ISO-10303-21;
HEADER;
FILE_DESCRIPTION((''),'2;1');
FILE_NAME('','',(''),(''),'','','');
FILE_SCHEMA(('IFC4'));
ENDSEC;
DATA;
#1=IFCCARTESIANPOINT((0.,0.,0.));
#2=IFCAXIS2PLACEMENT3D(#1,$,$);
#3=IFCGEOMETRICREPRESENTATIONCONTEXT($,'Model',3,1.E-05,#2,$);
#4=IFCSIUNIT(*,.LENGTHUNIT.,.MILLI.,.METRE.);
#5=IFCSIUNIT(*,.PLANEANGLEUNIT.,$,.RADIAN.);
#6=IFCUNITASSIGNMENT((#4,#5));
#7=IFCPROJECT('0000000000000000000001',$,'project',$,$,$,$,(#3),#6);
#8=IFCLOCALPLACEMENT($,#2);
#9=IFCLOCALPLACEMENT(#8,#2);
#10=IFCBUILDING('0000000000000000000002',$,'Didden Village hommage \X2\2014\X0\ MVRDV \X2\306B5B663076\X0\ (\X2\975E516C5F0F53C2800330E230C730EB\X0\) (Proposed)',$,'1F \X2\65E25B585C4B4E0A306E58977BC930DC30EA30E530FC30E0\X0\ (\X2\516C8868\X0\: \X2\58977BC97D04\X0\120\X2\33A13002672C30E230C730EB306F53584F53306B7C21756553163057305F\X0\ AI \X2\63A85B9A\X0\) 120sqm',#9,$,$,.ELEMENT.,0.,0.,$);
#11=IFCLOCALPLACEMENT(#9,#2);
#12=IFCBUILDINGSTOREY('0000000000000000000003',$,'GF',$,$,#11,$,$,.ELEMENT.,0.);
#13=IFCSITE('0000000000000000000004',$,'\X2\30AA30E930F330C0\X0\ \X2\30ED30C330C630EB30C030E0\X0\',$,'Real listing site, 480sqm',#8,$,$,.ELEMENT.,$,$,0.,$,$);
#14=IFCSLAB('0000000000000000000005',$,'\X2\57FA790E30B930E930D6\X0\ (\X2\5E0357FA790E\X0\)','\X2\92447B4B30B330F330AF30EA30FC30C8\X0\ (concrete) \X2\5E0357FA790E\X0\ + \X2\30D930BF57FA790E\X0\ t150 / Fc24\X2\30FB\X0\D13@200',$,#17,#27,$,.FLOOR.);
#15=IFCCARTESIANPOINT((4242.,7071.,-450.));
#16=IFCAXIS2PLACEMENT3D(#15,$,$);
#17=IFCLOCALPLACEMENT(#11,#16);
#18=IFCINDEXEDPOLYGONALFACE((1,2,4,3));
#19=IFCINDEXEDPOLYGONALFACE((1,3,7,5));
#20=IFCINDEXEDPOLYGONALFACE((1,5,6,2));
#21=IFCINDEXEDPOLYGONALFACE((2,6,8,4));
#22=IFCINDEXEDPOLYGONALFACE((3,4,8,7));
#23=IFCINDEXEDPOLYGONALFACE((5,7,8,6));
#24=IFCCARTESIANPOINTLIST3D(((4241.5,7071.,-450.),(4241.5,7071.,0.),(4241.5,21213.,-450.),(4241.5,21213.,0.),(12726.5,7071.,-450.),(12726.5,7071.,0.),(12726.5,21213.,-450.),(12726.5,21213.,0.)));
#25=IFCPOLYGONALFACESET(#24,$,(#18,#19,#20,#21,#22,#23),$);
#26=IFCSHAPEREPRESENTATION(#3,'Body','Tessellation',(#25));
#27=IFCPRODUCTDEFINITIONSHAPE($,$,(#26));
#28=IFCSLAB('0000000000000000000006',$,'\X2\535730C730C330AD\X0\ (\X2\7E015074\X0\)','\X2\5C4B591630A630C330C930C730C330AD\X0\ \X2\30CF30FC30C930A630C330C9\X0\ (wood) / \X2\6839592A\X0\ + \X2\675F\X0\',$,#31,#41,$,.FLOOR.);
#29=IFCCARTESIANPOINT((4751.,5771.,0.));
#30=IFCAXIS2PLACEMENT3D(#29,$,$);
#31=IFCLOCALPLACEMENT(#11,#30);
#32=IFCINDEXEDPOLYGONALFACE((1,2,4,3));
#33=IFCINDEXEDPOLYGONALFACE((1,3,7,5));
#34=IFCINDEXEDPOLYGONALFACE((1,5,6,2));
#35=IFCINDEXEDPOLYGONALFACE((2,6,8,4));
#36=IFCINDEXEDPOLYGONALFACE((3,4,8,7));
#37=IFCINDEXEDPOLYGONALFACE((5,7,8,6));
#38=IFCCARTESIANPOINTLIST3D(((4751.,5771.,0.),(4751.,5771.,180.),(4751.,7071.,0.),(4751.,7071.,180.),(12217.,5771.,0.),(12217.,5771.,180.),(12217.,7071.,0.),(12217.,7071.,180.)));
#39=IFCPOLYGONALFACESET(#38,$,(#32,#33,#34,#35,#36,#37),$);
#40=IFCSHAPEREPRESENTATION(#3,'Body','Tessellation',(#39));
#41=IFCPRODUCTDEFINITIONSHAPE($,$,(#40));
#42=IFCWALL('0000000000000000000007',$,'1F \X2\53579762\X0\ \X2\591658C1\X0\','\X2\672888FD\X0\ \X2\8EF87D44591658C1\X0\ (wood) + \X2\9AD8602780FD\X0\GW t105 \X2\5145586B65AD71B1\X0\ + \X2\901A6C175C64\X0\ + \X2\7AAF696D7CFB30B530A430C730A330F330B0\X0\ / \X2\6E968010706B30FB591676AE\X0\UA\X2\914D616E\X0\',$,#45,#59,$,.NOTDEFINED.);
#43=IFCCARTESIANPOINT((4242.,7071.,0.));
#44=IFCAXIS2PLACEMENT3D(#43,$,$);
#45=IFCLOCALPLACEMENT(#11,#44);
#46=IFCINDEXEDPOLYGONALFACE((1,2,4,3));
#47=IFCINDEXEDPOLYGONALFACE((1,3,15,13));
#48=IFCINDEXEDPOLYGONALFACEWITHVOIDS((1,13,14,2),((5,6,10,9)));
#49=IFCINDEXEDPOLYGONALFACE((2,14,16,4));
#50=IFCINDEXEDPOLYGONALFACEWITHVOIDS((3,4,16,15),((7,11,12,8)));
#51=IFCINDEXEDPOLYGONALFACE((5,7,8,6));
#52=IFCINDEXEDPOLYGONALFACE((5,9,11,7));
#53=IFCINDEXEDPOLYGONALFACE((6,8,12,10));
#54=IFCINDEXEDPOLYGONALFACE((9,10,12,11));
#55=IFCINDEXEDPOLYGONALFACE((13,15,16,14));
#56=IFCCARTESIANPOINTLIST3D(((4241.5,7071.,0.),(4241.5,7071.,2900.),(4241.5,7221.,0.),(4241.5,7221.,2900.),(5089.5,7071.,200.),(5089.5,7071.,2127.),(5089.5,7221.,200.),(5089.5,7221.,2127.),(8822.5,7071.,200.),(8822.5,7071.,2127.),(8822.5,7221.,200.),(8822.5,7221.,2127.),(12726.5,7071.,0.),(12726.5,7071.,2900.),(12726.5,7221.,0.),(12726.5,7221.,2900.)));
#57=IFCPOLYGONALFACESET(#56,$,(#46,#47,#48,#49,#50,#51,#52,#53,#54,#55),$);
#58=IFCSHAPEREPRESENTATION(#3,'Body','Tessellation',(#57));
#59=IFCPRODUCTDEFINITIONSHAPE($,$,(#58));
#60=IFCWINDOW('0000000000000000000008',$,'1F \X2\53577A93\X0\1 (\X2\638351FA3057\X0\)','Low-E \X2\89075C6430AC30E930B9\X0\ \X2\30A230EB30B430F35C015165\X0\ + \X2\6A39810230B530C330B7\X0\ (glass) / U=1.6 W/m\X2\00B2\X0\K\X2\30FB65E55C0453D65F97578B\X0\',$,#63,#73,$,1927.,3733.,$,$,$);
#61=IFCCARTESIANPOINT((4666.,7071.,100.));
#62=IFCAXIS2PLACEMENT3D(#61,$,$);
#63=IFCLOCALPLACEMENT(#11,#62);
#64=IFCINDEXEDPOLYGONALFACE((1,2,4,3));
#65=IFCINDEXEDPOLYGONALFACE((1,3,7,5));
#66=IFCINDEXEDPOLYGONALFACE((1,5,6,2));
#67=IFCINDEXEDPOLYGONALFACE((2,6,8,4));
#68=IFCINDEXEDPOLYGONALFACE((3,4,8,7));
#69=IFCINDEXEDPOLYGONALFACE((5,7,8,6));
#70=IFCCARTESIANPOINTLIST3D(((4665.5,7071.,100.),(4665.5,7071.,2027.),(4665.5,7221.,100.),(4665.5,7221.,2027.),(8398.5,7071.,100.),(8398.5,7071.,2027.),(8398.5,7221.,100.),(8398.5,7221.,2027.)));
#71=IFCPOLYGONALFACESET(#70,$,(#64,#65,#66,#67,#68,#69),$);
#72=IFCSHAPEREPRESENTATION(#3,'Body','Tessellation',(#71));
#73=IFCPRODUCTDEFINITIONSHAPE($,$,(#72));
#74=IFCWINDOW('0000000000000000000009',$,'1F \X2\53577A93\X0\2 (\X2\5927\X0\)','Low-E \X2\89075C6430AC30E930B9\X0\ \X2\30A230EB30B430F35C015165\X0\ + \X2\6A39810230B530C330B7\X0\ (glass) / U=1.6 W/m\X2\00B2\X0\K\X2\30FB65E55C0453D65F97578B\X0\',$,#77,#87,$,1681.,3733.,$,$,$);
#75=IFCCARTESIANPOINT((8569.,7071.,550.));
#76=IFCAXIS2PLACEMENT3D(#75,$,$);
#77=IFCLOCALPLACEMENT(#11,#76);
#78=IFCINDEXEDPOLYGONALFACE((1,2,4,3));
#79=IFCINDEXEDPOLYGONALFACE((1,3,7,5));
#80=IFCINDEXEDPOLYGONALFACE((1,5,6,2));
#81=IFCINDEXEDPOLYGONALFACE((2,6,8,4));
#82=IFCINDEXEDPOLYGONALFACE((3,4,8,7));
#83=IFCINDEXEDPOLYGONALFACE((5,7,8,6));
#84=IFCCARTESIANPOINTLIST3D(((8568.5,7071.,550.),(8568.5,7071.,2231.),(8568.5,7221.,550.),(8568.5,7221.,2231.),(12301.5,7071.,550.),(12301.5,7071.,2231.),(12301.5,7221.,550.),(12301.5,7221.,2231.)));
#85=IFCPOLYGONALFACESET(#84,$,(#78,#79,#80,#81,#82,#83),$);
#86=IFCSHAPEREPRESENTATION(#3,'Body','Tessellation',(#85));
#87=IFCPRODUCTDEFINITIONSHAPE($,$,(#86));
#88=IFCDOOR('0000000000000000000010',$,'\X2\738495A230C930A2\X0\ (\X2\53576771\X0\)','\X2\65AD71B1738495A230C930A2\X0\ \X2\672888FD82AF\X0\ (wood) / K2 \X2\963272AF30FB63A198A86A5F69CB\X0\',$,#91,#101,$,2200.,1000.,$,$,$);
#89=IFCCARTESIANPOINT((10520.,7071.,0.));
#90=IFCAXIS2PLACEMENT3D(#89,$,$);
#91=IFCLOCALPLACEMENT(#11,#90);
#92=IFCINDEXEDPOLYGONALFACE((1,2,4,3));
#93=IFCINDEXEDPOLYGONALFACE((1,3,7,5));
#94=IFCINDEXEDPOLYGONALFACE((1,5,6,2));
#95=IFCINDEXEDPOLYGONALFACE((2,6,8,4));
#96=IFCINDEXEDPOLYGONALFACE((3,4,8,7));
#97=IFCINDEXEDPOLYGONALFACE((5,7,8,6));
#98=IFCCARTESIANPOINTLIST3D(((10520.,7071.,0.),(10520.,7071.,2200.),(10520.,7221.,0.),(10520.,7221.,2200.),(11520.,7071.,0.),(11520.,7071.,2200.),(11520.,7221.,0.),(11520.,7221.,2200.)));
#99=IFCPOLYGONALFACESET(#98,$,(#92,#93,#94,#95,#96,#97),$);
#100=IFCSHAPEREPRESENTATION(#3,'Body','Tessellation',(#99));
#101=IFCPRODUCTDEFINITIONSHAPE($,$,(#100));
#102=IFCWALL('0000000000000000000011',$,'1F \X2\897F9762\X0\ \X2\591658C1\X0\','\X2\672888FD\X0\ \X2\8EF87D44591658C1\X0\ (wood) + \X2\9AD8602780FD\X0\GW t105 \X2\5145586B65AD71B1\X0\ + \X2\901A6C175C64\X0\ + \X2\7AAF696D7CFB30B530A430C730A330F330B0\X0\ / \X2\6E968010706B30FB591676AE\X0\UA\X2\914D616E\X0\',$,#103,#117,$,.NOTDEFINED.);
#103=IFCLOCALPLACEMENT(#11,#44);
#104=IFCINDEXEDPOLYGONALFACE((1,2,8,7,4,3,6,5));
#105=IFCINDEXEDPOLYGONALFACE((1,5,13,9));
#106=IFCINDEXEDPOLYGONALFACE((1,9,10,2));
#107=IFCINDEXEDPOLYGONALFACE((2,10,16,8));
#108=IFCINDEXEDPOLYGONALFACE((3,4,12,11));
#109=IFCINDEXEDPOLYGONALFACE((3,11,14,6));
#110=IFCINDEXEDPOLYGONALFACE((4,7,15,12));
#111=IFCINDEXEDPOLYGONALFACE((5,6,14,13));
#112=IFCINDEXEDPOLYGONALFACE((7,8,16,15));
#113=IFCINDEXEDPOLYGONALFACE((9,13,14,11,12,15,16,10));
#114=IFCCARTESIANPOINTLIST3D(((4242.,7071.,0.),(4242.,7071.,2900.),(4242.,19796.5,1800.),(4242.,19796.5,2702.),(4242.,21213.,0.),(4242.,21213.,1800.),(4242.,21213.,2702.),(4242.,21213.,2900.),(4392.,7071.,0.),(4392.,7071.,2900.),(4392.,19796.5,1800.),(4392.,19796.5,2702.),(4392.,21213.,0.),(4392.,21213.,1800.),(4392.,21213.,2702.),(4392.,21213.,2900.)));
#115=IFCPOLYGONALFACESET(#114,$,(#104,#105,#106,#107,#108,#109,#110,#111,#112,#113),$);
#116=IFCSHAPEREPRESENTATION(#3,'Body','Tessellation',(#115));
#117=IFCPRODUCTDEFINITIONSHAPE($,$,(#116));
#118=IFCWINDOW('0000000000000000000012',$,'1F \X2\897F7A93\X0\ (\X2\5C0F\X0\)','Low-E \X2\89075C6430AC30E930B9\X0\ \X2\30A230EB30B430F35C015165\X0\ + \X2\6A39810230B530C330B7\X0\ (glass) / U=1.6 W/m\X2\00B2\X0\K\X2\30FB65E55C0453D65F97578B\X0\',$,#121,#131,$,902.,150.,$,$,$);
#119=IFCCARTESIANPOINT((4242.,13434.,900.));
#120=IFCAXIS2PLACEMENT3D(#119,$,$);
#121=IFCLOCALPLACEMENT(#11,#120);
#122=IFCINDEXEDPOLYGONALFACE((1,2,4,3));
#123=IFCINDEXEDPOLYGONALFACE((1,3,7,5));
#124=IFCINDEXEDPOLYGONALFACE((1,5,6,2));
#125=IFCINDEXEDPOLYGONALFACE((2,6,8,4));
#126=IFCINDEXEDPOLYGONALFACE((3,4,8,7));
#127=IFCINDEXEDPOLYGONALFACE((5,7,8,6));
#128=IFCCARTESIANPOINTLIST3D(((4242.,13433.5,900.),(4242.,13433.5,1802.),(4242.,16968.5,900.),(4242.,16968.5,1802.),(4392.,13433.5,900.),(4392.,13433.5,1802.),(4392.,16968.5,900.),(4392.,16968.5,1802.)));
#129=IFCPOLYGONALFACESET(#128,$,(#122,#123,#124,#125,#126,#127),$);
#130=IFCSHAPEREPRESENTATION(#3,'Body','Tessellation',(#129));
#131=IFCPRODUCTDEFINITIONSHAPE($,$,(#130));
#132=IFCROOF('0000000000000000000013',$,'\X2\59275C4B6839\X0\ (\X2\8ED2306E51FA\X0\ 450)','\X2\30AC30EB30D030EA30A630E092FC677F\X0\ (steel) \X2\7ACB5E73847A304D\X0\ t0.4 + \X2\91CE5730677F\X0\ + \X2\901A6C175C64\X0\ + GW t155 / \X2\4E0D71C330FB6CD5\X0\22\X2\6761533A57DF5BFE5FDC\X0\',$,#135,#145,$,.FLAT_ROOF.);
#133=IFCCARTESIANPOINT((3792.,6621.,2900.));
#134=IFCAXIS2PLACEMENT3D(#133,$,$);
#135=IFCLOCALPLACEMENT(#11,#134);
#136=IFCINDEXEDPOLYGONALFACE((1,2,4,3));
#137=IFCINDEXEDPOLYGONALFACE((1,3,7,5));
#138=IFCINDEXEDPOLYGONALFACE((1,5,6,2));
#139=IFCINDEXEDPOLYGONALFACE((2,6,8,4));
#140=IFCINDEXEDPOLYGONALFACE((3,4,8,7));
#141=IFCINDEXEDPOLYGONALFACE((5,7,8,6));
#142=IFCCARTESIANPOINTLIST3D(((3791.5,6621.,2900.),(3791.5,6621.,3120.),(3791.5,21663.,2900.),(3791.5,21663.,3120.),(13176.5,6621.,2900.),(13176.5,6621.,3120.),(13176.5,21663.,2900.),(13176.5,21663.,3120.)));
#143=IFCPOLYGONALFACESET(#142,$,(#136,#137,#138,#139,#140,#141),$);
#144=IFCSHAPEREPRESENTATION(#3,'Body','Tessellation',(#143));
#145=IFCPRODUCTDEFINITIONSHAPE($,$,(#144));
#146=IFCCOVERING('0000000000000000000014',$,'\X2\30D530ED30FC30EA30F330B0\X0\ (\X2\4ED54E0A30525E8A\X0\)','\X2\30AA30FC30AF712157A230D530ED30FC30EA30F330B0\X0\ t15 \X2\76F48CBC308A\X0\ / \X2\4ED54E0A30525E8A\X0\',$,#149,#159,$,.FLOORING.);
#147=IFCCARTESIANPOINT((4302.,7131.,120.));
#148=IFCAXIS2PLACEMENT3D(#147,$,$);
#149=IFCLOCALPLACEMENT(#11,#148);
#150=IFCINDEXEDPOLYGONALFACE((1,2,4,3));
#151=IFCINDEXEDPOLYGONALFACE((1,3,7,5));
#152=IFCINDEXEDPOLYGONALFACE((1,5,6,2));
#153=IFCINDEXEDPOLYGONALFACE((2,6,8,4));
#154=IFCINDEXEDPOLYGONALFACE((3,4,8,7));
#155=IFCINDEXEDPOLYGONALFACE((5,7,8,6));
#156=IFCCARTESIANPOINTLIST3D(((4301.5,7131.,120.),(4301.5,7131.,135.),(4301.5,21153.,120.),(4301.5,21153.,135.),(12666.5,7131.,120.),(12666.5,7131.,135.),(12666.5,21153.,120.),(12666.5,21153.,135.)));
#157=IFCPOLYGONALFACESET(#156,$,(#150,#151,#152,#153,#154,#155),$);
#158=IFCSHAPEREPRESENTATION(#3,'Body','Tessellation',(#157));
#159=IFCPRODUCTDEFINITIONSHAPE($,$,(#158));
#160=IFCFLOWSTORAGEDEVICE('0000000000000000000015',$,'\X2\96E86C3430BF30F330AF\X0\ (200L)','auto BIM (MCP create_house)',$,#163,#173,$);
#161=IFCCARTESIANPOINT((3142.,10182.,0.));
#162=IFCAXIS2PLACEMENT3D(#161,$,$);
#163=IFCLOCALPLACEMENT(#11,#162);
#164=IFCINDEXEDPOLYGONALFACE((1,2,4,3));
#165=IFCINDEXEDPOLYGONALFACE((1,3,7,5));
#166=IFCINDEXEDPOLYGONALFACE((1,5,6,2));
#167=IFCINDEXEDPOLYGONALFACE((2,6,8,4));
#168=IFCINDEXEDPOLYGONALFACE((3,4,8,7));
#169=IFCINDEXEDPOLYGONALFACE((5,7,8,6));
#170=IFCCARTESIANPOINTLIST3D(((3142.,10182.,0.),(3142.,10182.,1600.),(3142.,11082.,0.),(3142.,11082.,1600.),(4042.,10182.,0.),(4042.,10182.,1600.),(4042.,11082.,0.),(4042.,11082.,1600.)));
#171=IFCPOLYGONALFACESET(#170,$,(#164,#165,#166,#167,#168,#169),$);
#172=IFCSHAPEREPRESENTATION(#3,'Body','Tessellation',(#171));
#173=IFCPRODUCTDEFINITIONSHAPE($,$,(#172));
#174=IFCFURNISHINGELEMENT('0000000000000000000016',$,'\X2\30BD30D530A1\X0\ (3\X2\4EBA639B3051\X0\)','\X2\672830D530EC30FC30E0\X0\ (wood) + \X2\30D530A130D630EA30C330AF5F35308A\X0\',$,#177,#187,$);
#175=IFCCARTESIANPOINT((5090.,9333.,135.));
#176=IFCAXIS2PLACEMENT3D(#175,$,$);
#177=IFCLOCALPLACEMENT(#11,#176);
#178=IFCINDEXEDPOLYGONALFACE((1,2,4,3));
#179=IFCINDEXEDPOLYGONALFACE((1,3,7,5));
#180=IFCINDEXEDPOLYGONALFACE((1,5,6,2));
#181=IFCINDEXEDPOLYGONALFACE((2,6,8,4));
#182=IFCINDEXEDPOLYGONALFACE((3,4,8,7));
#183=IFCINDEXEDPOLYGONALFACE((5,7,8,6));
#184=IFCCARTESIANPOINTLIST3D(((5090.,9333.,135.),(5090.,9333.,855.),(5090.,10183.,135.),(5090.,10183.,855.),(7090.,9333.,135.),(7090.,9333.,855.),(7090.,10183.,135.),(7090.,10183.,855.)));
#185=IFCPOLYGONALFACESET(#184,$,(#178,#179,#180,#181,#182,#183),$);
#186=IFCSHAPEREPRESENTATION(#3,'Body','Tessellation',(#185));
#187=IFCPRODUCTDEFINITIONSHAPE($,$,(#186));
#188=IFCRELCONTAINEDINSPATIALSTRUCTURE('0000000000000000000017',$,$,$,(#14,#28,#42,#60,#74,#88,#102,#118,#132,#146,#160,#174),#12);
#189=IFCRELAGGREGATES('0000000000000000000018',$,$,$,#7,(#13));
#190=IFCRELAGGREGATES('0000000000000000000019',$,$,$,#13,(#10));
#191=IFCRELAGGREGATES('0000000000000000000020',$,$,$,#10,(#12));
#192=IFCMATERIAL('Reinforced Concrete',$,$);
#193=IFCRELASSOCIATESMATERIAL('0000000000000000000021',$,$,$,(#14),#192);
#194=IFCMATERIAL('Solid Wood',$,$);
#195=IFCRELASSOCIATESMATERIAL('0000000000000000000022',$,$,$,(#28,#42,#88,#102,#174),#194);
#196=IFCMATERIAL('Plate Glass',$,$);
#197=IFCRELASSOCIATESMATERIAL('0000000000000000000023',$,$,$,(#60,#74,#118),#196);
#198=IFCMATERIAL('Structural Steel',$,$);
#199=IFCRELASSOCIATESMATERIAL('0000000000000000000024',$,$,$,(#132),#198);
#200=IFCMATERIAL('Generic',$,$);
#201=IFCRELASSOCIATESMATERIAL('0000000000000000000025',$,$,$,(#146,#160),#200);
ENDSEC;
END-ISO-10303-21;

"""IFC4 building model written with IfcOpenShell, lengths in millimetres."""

from ifc_helpers import new_model, si_unit, frame, frame_2d, origin, place, context, project, spatial, rectangle, extrude, material, element, fill, save


model = new_model("IFC4")

# Units and contexts
model_context = context("Model", 3, precision=1e-05, world=origin())
ifc_project = project(units=[si_unit("LENGTHUNIT", "METRE", prefix="MILLI"), si_unit("PLANEANGLEUNIT", "RADIAN")], contexts=[model_context])

# Site, building, storey
site_placement = place(None, origin())
site = spatial("IfcSite", under=ifc_project, at=site_placement, Name="オランダ ロッテルダム", ObjectType="Real listing site, 480sqm", CompositionType="ELEMENT", RefElevation=0.0)
building_placement = place(site_placement, origin())
building = spatial("IfcBuilding", under=site, at=building_placement, Name="Didden Village hommage — MVRDV に学ぶ (非公式参考モデル) (Proposed)", ObjectType="1F 既存屋上の増築ボリューム (公表: 増築約120㎡。本モデルは単体に簡略化した AI 推定) 120sqm", CompositionType="ELEMENT", ElevationOfRefHeight=0.0, ElevationOfTerrain=0.0)
storey_placement = place(building_placement, origin())
storey = spatial("IfcBuildingStorey", under=building, at=storey_placement, Name="GF", CompositionType="ELEMENT", Elevation=0.0)

# Slabs
ifc_material_1 = material(Name="Reinforced Concrete")
slab_1_placement = place(storey_placement, frame((4242.0, 7071.0, -450.0)))
element("IfcSlab", 1, at=slab_1_placement, inside=storey, material=ifc_material_1, Name="基礎スラブ (布基礎)", Description="鉄筋コンクリート (concrete) 布基礎 + ベタ基礎 t150 / Fc24・D13@200", PredefinedType="FLOOR", context=model_context, shape_type="SweptSolid", body=[
    extrude(rectangle(XDim=8485.0, YDim=14142.0, at=frame_2d((4242.0, 7071.0))), frame((4242.0, 7071.0, -450.0)), (0.0, 0.0, 1.0), 450.0),
])
ifc_material_2 = material(Name="Solid Wood")
slab_2_placement = place(storey_placement, frame((4751.0, 5771.0, 0.0)))
element("IfcSlab", 2, at=slab_2_placement, inside=storey, material=ifc_material_2, Name="南デッキ (縁側)", Description="屋外ウッドデッキ ハードウッド (wood) / 根太 + 束", PredefinedType="FLOOR", context=model_context, shape_type="SweptSolid", body=[
    extrude(rectangle(XDim=7466.0, YDim=1300.0, at=frame_2d((3733.0, 650.0))), frame((4751.0, 5771.0, 0.0)), (0.0, 0.0, 1.0), 180.0),
])

# Wall, openings, windows, door
wall_1_placement = place(storey_placement, frame((4242.0, 7071.0, 0.0)))
wall_1 = element("IfcWall", 3, at=wall_1_placement, inside=storey, material=ifc_material_2, Name="1F 南面 外壁", Description="木製 軸組外壁 (wood) + 高性能GW t105 充填断熱 + 通気層 + 窯業系サイディング / 準耐火・外皮UA配慮", PredefinedType="NOTDEFINED", context=model_context, shape_type="SweptSolid", body=[
    extrude(rectangle(XDim=8485.0, YDim=150.0, at=frame_2d((4242.0, 75.0))), frame((4242.0, 7071.0, 0.0)), (0.0, 0.0, 1.0), 2900.0),
])
opening_1_placement = place(storey_placement, frame((4666.0, 7071.0, 100.0)))
opening_1 = element("IfcOpeningElement", 4, at=opening_1_placement, cuts=wall_1, PredefinedType="NOTDEFINED", context=model_context, shape_type="SweptSolid", body=[
    extrude(rectangle(XDim=3733.0, YDim=150.0, at=frame_2d((1866.0, 75.0))), frame((4666.0, 7071.0, 100.0)), (0.0, 0.0, 1.0), 1927.0),
])
opening_2_placement = place(storey_placement, frame((8569.0, 7071.0, 550.0)))
opening_2 = element("IfcOpeningElement", 5, at=opening_2_placement, cuts=wall_1, PredefinedType="NOTDEFINED", context=model_context, shape_type="SweptSolid", body=[
    extrude(rectangle(XDim=3733.0, YDim=150.0, at=frame_2d((1866.0, 75.0))), frame((8569.0, 7071.0, 550.0)), (0.0, 0.0, 1.0), 1681.0),
])
opening_3_placement = place(storey_placement, frame((10520.0, 7071.0, 0.0)))
opening_3 = element("IfcOpeningElement", 6, at=opening_3_placement, cuts=wall_1, PredefinedType="NOTDEFINED", context=model_context, shape_type="SweptSolid", body=[
    extrude(rectangle(XDim=1000.0, YDim=150.0, at=frame_2d((500.0, 75.0))), frame((10520.0, 7071.0, 0.0)), (0.0, 0.0, 1.0), 2200.0),
])
ifc_material_3 = material(Name="Plate Glass")
window_1_placement = place(storey_placement, frame((4666.0, 7071.0, 100.0)))
window_1 = element("IfcWindow", 7, at=window_1_placement, inside=storey, material=ifc_material_3, Name="1F 南窓1 (掃出し)", Description="Low-E 複層ガラス アルゴン封入 + 樹脂サッシ (glass) / U=1.6 W/m²K・日射取得型", OverallHeight=1927.0, OverallWidth=3733.0, context=model_context, shape_type="SweptSolid", body=[
    extrude(rectangle(XDim=3733.0, YDim=150.0, at=frame_2d((1866.0, 75.0))), frame((4666.0, 7071.0, 100.0)), (0.0, 0.0, 1.0), 1927.0),
])
fill(opening_1, window_1)
window_2_placement = place(storey_placement, frame((8569.0, 7071.0, 550.0)))
window_2 = element("IfcWindow", 8, at=window_2_placement, inside=storey, material=ifc_material_3, Name="1F 南窓2 (大)", Description="Low-E 複層ガラス アルゴン封入 + 樹脂サッシ (glass) / U=1.6 W/m²K・日射取得型", OverallHeight=1681.0, OverallWidth=3733.0, context=model_context, shape_type="SweptSolid", body=[
    extrude(rectangle(XDim=3733.0, YDim=150.0, at=frame_2d((1866.0, 75.0))), frame((8569.0, 7071.0, 550.0)), (0.0, 0.0, 1.0), 1681.0),
])
fill(opening_2, window_2)
door_placement = place(storey_placement, frame((10520.0, 7071.0, 0.0)))
door = element("IfcDoor", 9, at=door_placement, inside=storey, material=ifc_material_2, Name="玄関ドア (南東)", Description="断熱玄関ドア 木製芯 (wood) / K2 防犯・採風機構", OverallHeight=2200.0, OverallWidth=1000.0, context=model_context, shape_type="SweptSolid", body=[
    extrude(rectangle(XDim=1000.0, YDim=150.0, at=frame_2d((500.0, 75.0))), frame((10520.0, 7071.0, 0.0)), (0.0, 0.0, 1.0), 2200.0),
])
fill(opening_3, door)

# Wall, opening, window
wall_2_placement = place(storey_placement, frame((4242.0, 7071.0, 0.0)))
wall_2 = element("IfcWall", 10, at=wall_2_placement, inside=storey, material=ifc_material_2, Name="1F 西面 外壁", Description="木製 軸組外壁 (wood) + 高性能GW t105 充填断熱 + 通気層 + 窯業系サイディング / 準耐火・外皮UA配慮", PredefinedType="NOTDEFINED", context=model_context, shape_type="SweptSolid", body=[
    extrude(rectangle(XDim=150.0, YDim=14142.0, at=frame_2d((75.0, 7071.0))), frame((4242.0, 7071.0, 0.0)), (0.0, 0.0, 1.0), 2900.0),
])
opening_4_placement = place(storey_placement, frame((4242.0, 13434.0, 900.0)))
opening_4 = element("IfcOpeningElement", 11, at=opening_4_placement, cuts=wall_2, PredefinedType="NOTDEFINED", context=model_context, shape_type="SweptSolid", body=[
    extrude(rectangle(XDim=150.0, YDim=3535.0, at=frame_2d((75.0, 1767.0))), frame((4242.0, 13434.0, 900.0)), (0.0, 0.0, 1.0), 902.0),
])
window_3_placement = place(storey_placement, frame((4242.0, 13434.0, 900.0)))
window_3 = element("IfcWindow", 12, at=window_3_placement, inside=storey, material=ifc_material_3, Name="1F 西窓 (小)", Description="Low-E 複層ガラス アルゴン封入 + 樹脂サッシ (glass) / U=1.6 W/m²K・日射取得型", OverallHeight=902.0, OverallWidth=150.0, context=model_context, shape_type="SweptSolid", body=[
    extrude(rectangle(XDim=150.0, YDim=3535.0, at=frame_2d((75.0, 1767.0))), frame((4242.0, 13434.0, 900.0)), (0.0, 0.0, 1.0), 902.0),
])
fill(opening_4, window_3)

# Roof
ifc_material_4 = material(Name="Structural Steel")
roof_placement = place(storey_placement, frame((3792.0, 6621.0, 2900.0)))
element("IfcRoof", 13, at=roof_placement, inside=storey, material=ifc_material_4, Name="大屋根 (軒の出 450)", Description="ガルバリウム鋼板 (steel) 立平葺き t0.4 + 野地板 + 通気層 + GW t155 / 不燃・法22条区域対応", PredefinedType="FLAT_ROOF", context=model_context, shape_type="SweptSolid", body=[
    extrude(rectangle(XDim=9385.0, YDim=15042.0, at=frame_2d((4692.0, 7521.0))), frame((3792.0, 6621.0, 2900.0)), (0.0, 0.0, 1.0), 220.0),
])

# Covering
ifc_material_5 = material(Name="Generic")
covering_placement = place(storey_placement, frame((4302.0, 7131.0, 120.0)))
element("IfcCovering", 14, at=covering_placement, inside=storey, material=ifc_material_5, Name="フローリング (仕上げ床)", Description="オーク無垢フローリング t15 直貼り / 仕上げ床", PredefinedType="FLOORING", context=model_context, shape_type="SweptSolid", body=[
    extrude(rectangle(XDim=8365.0, YDim=14022.0, at=frame_2d((4182.0, 7011.0))), frame((4302.0, 7131.0, 120.0)), (0.0, 0.0, 1.0), 15.0),
])

# Flow storage device
flow_storage_device_placement = place(storey_placement, frame((3142.0, 10182.0, 0.0)))
element("IfcFlowStorageDevice", 15, at=flow_storage_device_placement, inside=storey, material=ifc_material_5, Name="雨水タンク (200L)", Description="auto BIM (MCP create_house)", context=model_context, shape_type="SweptSolid", body=[
    extrude(rectangle(XDim=900.0, YDim=900.0, at=frame_2d((450.0, 450.0))), frame((3142.0, 10182.0, 0.0)), (0.0, 0.0, 1.0), 1600.0),
])

# Furnishing element
furnishing_1_placement = place(storey_placement, frame((5090.0, 9333.0, 135.0)))
element("IfcFurnishingElement", 16, at=furnishing_1_placement, inside=storey, material=ifc_material_2, Name="ソファ (3人掛け)", Description="木フレーム (wood) + ファブリック張り", context=model_context, shape_type="SweptSolid", body=[
    extrude(rectangle(XDim=2000.0, YDim=850.0, at=frame_2d((1000.0, 425.0))), frame((5090.0, 9333.0, 135.0)), (0.0, 0.0, 1.0), 720.0),
])

save(model, "model.ifc")
